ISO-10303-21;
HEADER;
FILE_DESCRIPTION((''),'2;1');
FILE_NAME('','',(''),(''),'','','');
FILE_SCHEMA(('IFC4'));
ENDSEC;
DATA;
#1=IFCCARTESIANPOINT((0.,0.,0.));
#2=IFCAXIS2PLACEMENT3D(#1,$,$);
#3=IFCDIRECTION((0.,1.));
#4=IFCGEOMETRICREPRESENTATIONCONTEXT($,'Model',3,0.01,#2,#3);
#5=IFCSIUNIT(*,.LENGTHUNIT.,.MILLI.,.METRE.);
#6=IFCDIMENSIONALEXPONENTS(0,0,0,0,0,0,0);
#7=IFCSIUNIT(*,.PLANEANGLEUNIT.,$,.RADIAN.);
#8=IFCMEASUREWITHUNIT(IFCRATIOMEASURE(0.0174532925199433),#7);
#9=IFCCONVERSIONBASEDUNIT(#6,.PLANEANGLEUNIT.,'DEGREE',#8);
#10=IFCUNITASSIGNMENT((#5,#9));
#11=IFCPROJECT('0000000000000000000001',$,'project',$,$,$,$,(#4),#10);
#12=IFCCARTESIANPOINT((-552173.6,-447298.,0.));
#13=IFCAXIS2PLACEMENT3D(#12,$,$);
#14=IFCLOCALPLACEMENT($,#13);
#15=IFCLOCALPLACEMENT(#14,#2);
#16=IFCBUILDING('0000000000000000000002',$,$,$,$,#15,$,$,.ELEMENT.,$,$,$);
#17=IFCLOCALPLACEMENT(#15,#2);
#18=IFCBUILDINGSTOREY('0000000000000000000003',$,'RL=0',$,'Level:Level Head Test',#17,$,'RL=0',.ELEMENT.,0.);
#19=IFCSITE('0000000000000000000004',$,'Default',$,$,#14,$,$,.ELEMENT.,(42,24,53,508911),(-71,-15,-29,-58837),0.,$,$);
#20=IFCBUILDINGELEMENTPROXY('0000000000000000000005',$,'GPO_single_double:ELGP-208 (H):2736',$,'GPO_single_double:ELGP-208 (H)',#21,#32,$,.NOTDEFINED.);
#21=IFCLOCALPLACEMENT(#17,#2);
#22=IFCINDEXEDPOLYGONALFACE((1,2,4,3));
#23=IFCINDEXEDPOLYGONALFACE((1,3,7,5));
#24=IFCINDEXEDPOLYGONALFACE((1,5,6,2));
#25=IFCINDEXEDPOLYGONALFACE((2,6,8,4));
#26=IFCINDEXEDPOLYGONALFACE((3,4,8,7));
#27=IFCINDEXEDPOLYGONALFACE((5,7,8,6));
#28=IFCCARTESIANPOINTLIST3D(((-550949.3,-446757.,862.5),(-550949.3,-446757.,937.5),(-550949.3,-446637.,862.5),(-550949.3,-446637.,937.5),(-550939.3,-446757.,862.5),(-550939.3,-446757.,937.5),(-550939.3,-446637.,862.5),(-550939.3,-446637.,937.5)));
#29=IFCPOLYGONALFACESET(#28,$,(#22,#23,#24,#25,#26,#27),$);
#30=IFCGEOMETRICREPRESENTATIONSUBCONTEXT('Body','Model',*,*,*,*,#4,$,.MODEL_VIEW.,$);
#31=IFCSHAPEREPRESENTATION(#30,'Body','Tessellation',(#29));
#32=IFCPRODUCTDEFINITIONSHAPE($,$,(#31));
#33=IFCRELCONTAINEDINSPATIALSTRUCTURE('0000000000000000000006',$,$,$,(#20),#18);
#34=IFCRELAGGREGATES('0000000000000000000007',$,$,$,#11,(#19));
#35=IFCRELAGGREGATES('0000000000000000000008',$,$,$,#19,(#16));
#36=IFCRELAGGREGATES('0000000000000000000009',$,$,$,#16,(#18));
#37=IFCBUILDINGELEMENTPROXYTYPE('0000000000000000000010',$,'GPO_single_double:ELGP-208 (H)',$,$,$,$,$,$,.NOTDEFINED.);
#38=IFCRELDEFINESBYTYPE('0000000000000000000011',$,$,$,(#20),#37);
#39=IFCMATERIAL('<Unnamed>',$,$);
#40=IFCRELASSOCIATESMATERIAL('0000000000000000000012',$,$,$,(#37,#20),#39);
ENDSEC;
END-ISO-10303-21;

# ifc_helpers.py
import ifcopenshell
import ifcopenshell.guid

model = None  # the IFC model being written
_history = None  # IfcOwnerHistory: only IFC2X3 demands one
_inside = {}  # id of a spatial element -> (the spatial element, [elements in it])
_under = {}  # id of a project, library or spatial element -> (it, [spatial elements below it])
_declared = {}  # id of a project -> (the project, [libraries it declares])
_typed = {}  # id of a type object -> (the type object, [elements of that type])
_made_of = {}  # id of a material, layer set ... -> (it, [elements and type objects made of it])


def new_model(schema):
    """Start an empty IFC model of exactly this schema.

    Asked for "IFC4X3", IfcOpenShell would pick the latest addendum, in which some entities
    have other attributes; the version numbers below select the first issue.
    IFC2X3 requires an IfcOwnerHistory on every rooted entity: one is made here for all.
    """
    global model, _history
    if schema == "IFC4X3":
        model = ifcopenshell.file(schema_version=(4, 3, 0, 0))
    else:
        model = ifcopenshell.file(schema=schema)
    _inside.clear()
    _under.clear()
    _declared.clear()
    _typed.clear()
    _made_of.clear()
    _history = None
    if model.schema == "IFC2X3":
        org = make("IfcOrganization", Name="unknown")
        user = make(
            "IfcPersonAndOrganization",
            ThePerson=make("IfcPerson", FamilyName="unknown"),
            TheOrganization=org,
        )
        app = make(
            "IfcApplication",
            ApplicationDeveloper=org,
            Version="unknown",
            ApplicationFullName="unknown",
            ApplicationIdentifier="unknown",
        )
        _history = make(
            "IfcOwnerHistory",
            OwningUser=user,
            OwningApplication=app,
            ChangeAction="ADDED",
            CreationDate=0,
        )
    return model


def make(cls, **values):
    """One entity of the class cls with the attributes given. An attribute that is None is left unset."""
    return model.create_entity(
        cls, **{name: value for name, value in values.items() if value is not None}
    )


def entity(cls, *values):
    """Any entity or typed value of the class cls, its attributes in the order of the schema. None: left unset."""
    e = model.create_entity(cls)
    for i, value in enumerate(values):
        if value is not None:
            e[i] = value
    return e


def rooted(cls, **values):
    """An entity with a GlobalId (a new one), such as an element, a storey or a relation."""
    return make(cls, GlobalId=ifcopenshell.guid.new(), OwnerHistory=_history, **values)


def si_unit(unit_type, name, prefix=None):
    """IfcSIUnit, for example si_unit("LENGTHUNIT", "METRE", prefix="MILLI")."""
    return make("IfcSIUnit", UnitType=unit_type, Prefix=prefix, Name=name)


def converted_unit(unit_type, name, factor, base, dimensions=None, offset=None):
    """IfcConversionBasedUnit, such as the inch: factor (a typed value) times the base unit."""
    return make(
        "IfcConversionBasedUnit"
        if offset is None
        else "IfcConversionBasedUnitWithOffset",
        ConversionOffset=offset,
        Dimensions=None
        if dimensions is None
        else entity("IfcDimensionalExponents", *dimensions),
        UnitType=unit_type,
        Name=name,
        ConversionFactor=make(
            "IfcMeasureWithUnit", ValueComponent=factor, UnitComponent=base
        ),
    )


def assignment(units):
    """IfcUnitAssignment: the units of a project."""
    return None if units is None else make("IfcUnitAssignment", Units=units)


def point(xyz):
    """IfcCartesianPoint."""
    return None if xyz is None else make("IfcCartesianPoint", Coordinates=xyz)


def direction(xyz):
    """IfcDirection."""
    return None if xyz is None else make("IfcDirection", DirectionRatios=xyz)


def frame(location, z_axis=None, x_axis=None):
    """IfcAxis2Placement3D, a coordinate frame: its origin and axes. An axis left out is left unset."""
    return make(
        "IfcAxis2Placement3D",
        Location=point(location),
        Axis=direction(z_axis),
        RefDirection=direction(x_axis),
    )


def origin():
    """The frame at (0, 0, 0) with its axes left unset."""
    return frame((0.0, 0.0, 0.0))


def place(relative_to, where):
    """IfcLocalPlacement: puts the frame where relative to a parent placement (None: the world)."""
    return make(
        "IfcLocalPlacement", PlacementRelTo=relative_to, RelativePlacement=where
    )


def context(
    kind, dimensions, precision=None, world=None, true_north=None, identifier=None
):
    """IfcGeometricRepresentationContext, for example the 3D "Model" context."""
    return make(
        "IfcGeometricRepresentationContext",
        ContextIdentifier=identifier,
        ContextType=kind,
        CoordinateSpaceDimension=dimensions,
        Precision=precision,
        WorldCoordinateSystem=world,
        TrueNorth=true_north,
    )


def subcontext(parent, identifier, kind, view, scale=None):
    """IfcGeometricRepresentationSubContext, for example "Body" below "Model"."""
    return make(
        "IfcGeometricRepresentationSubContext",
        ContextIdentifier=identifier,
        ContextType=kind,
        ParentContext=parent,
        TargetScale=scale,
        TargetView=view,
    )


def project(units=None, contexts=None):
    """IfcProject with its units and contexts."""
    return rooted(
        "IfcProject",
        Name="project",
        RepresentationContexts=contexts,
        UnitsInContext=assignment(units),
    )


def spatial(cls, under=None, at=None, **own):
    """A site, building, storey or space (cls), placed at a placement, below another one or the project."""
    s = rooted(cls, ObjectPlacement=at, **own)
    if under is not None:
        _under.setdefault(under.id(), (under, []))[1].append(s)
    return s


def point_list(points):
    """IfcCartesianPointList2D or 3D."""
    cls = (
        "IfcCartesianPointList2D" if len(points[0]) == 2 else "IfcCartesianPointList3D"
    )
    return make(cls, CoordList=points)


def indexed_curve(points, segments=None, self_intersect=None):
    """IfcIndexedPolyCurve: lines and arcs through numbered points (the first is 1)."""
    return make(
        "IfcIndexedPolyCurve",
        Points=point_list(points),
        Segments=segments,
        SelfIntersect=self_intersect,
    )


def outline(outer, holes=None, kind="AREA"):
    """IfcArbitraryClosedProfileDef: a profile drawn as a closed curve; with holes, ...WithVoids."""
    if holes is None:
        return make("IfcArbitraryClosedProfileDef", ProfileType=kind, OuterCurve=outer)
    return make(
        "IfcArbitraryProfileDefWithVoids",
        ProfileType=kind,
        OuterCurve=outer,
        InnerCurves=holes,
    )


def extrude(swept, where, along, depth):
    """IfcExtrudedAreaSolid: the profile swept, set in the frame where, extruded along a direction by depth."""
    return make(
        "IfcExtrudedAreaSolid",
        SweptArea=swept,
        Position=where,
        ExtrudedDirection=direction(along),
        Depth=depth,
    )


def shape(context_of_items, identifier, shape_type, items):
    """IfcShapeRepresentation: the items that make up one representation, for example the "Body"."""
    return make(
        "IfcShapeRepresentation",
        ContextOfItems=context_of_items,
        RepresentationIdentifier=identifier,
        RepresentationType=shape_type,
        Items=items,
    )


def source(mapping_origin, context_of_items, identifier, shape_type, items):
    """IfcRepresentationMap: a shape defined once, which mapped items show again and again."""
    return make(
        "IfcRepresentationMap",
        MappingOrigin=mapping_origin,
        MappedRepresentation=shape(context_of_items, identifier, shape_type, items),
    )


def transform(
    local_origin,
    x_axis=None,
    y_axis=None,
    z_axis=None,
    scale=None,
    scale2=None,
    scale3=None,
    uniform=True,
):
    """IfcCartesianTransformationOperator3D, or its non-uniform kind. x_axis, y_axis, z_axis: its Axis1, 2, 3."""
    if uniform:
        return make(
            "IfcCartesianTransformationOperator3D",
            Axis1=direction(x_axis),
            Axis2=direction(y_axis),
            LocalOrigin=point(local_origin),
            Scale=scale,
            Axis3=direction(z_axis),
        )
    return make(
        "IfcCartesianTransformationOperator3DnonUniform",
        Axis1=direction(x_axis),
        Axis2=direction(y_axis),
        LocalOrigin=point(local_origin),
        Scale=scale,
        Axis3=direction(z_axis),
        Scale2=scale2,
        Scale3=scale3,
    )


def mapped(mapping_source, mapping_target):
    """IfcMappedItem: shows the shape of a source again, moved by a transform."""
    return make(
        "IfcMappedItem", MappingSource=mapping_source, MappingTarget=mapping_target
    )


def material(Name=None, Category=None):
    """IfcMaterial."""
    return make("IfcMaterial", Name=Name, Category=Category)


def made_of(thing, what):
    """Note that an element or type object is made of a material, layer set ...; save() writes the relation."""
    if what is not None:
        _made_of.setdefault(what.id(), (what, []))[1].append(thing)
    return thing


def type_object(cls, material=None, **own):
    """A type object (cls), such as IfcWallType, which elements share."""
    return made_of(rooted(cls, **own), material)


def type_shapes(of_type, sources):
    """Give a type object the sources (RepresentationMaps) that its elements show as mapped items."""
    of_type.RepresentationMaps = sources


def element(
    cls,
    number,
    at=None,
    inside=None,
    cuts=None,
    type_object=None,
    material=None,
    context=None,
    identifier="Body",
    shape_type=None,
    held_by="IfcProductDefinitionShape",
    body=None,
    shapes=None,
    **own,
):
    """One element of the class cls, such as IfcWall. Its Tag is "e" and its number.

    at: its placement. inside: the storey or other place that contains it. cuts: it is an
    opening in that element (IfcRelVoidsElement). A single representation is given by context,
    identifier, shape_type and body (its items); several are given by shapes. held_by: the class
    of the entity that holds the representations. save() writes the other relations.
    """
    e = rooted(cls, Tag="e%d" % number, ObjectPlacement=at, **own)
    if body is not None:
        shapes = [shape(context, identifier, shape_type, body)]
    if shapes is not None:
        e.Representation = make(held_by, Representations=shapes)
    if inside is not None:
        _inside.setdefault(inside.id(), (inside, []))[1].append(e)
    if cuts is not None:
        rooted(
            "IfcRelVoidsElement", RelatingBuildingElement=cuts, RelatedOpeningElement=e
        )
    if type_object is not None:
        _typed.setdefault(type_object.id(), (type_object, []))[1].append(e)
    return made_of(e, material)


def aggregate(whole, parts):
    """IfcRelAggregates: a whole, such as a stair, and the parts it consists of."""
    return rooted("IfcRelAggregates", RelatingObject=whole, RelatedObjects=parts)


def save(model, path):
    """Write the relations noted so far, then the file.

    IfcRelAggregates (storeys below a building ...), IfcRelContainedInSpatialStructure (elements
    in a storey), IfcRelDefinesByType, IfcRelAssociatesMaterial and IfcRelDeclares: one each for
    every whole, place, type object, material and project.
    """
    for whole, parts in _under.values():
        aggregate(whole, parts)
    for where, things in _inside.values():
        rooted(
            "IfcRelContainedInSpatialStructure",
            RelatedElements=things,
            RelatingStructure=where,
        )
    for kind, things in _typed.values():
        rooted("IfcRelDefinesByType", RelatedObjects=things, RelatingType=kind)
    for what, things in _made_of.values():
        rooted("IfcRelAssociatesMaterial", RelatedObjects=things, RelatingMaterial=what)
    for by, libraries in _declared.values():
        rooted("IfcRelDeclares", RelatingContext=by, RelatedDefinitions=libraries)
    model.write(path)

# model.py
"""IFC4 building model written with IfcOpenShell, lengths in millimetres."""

from ifc_helpers import new_model, entity, si_unit, converted_unit, direction, frame, origin, place, context, subcontext, project, spatial, indexed_curve, outline, extrude, source, transform, mapped, material, type_object, type_shapes, element, save


model = new_model("IFC4")

# Units and contexts
model_context = context("Model", 3, precision=0.01, world=origin(), true_north=direction((0.0, 1.0)))
body_context = subcontext(model_context, "Body", "Model", "MODEL_VIEW")
ifc_project = project(units=[si_unit("LENGTHUNIT", "METRE", prefix="MILLI"), converted_unit("PLANEANGLEUNIT", "DEGREE", entity("IfcRatioMeasure", 0.0174532925199433), si_unit("PLANEANGLEUNIT", "RADIAN"), dimensions=[0, 0, 0, 0, 0, 0, 0])], contexts=[model_context])

# Site, building, storey
site_placement = place(None, frame((-552173.6, -447298.0, 0.0)))
site = spatial("IfcSite", under=ifc_project, at=site_placement, Name="Default", CompositionType="ELEMENT", RefLatitude=(42, 24, 53, 508911), RefLongitude=(-71, -15, -29, -58837), RefElevation=0.0)
building_placement = place(site_placement, origin())
building = spatial("IfcBuilding", under=site, at=building_placement, CompositionType="ELEMENT")
storey_placement = place(building_placement, origin())
storey = spatial("IfcBuildingStorey", under=building, at=storey_placement, Name="RL=0", ObjectType="Level:Level Head Test", LongName="RL=0", CompositionType="ELEMENT", Elevation=0.0)

# Shared definitions
ifc_material_1 = material(Name="<Unnamed>")

# Building element proxy
building_element_proxy_type_1 = type_object("IfcBuildingElementProxyType", Name="GPO_single_double:ELGP-208 (H)", PredefinedType="NOTDEFINED", material=ifc_material_1)
shared_shape_1 = source(origin(), body_context, "Body", "SweptSolid", [
    extrude(outline(indexed_curve([(-5.0, -60.0), (5.0, -60.0), (5.0, 60.0), (-5.0, 60.0), (-5.0, -60.0)], self_intersect=False)), frame((0.0, -5.0, -37.5), z_axis=(0.0, 0.0, 1.0), x_axis=(0.0, 1.0, 0.0)), (0.0, 0.0, 1.0), 75.0),
])
type_shapes(building_element_proxy_type_1, [shared_shape_1])
for number, where, z_axis, x_axis, name in (
    (1, (-550939.3, -446697.0, 900.0), (0.0, 0.0, 1.0), (0.0, -1.0, 0.0), "GPO_single_double:ELGP-208 (H):2736"),
):
    element("IfcBuildingElementProxy", number, at=place(storey_placement, frame(where, z_axis=z_axis, x_axis=x_axis)), inside=storey, type_object=building_element_proxy_type_1, material=ifc_material_1, Name=name, ObjectType="GPO_single_double:ELGP-208 (H)", PredefinedType="NOTDEFINED", context=body_context, shape_type="MappedRepresentation", body=[
        mapped(shared_shape_1, transform((0.0, 0.0, 0.0), scale=1.0)),
    ])

save(model, "model.ifc")
